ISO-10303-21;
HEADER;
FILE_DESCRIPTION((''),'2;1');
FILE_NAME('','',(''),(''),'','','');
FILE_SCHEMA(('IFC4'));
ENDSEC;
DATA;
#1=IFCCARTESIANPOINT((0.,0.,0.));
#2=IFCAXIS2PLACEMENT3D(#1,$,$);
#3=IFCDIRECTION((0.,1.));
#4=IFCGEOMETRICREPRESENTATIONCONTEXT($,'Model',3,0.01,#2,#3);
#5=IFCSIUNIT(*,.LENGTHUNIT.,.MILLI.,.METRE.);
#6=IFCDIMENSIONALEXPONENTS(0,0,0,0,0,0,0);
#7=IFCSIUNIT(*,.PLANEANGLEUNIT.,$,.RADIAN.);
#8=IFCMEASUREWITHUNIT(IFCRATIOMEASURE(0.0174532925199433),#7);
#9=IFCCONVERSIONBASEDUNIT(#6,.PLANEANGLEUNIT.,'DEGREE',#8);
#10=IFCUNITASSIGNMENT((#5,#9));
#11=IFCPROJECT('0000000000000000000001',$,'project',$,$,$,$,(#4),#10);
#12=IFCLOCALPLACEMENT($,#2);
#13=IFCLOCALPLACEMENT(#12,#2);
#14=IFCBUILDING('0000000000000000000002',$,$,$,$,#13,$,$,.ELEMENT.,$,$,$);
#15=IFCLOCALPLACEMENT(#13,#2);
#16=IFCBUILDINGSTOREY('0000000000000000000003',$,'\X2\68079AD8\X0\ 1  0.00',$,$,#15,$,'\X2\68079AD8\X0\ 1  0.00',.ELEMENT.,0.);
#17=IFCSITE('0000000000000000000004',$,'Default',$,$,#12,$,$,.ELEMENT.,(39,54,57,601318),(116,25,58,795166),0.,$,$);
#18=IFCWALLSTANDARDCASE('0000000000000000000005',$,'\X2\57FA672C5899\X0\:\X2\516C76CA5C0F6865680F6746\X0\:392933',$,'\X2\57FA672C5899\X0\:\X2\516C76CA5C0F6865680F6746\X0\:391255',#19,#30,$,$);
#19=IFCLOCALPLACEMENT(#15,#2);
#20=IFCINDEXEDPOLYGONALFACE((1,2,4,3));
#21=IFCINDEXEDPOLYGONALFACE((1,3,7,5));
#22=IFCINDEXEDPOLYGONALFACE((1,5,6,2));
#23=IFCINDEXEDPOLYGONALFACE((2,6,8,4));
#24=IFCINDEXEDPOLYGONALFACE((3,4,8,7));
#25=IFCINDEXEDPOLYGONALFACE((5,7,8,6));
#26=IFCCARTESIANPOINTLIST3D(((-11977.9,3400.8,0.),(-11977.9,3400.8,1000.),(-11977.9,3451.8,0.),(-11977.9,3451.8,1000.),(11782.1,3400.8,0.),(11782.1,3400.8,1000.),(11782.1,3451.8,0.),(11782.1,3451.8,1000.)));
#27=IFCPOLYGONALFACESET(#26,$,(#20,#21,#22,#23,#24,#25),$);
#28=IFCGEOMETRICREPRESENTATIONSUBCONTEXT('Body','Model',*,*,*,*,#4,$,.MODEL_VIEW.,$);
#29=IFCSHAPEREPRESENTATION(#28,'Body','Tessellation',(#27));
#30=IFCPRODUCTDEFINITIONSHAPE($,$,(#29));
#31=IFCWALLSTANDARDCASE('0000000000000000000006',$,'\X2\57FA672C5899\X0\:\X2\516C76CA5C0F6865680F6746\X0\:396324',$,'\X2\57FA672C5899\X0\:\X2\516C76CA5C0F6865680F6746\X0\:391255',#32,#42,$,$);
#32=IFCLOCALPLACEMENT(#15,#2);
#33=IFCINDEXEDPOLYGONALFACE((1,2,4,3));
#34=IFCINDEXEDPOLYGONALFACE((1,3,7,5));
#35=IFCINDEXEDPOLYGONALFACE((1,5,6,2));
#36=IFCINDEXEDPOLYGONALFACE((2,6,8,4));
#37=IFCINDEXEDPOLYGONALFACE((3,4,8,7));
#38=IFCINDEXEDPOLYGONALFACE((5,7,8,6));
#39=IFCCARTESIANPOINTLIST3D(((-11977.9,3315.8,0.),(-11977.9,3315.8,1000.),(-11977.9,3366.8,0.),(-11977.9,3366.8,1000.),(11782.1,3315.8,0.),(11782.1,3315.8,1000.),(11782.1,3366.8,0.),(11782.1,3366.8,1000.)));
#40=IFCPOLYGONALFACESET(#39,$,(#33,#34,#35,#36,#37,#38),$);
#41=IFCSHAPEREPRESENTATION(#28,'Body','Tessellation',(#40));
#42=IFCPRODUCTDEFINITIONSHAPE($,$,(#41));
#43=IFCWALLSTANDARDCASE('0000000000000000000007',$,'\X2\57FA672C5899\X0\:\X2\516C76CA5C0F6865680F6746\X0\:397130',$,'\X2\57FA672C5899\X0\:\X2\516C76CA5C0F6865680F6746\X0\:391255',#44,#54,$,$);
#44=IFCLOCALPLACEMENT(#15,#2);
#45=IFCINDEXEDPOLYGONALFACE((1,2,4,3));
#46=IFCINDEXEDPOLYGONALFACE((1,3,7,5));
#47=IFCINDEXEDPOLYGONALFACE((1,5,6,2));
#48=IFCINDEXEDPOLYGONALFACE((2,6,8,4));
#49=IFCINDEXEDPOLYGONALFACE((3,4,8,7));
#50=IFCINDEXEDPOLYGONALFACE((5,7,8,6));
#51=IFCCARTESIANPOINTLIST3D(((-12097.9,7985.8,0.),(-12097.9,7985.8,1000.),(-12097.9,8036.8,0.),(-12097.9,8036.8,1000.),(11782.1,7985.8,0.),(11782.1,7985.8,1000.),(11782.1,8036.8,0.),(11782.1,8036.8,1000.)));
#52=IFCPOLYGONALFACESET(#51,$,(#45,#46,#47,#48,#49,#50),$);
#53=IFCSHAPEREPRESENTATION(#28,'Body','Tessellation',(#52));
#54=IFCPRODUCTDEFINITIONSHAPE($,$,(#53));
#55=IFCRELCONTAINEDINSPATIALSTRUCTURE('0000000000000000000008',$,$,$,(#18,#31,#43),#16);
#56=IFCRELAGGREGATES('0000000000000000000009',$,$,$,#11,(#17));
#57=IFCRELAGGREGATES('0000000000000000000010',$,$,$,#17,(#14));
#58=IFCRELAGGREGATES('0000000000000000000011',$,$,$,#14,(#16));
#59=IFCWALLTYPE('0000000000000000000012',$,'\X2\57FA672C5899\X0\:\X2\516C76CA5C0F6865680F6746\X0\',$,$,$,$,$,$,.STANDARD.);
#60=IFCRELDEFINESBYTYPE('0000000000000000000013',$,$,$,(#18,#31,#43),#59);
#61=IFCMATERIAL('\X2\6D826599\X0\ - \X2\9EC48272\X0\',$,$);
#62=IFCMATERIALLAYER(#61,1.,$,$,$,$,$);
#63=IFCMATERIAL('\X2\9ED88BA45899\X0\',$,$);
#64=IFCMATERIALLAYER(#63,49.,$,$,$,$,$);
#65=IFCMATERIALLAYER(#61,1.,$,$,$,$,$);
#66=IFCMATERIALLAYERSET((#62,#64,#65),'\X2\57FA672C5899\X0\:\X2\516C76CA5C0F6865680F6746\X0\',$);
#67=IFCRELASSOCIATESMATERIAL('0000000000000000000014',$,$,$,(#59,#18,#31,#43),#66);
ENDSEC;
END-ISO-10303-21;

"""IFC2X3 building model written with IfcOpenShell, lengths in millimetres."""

from ifc_helpers import new_model, entity, si_unit, converted_unit, direction, frame, frame_2d, origin, place, context, subcontext, project, spatial, rectangle, extrude, material, layer, layer_set, layer_usage, type_object, element, save


model = new_model("IFC2X3")

# Units and contexts
model_context = context("Model", 3, precision=0.01, world=origin(), true_north=direction((0.0, 1.0)))
body_context = subcontext(model_context, "Body", "Model", "MODEL_VIEW")
ifc_project = project(units=[si_unit("LENGTHUNIT", "METRE", prefix="MILLI"), converted_unit("PLANEANGLEUNIT", "DEGREE", entity("IfcRatioMeasure", 0.0174532925199433), si_unit("PLANEANGLEUNIT", "RADIAN"), dimensions=[0, 0, 0, 0, 0, 0, 0])], contexts=[model_context])

# Site, building, storey
site_placement = place(None, origin())
site = spatial("IfcSite", under=ifc_project, at=site_placement, Name="Default", CompositionType="ELEMENT", RefLatitude=(39, 54, 57, 601318), RefLongitude=(116, 25, 58, 795166), RefElevation=0.0)
building_placement = place(site_placement, origin())
building = spatial("IfcBuilding", under=site, at=building_placement, CompositionType="ELEMENT")
storey_placement = place(building_placement, origin())
storey = spatial("IfcBuildingStorey", under=building, at=storey_placement, Name="标高 1  0.00", LongName="标高 1  0.00", CompositionType="ELEMENT", Elevation=0.0)

# Walls
ifc_material_1 = material(Name="涂料 - 黄色")
ifc_layer_1 = layer(ifc_material_1, 1.0)
ifc_material_2 = material(Name="默认墙")
ifc_layer_2 = layer(ifc_material_2, 49.0)
ifc_layer_3 = layer(ifc_material_1, 1.0)
ifc_layer_set_1 = layer_set([ifc_layer_1, ifc_layer_2, ifc_layer_3], Name="基本墙:公益小桥栏杆")
ifc_layer_usage_1 = layer_usage(ifc_layer_set_1, "AXIS2", "NEGATIVE", 25.5)
wall_type = type_object("IfcWallType", Name="基本墙:公益小桥栏杆", PredefinedType="STANDARD", material=ifc_layer_set_1)
wall_1_placement = place(storey_placement, frame((11782.1, 3426.3, 0.0), z_axis=(0.0, 0.0, 1.0), x_axis=(-1.0, 0.0, 0.0)))
element("IfcWallStandardCase", 1, at=wall_1_placement, inside=storey, type_object=wall_type, material=ifc_layer_usage_1, Name="基本墙:公益小桥栏杆:392933", ObjectType="基本墙:公益小桥栏杆:391255", context=body_context, shape_type="SweptSolid", body=[
    extrude(rectangle(XDim=23760.0, YDim=51.0, at=frame_2d((11880.0, 0.0), x_axis=(-1.0, 0.0))), origin(), (0.0, 0.0, 1.0), 1000.0),
])
ifc_layer_usage_2 = layer_usage(ifc_layer_set_1, "AXIS2", "NEGATIVE", 25.5)
wall_2_placement = place(storey_placement, frame((11782.1, 3341.3, 0.0), z_axis=(0.0, 0.0, 1.0), x_axis=(-1.0, 0.0, 0.0)))
element("IfcWallStandardCase", 2, at=wall_2_placement, inside=storey, type_object=wall_type, material=ifc_layer_usage_2, Name="基本墙:公益小桥栏杆:396324", ObjectType="基本墙:公益小桥栏杆:391255", context=body_context, shape_type="SweptSolid", body=[
    extrude(rectangle(XDim=23760.0, YDim=51.0, at=frame_2d((11880.0, 0.0), x_axis=(-1.0, 0.0))), origin(), (0.0, 0.0, 1.0), 1000.0),
])
ifc_layer_usage_3 = layer_usage(ifc_layer_set_1, "AXIS2", "NEGATIVE", 25.5)
wall_3_placement = place(storey_placement, frame((11782.1, 8011.3, 0.0), z_axis=(0.0, 0.0, 1.0), x_axis=(-1.0, 0.0, 0.0)))
element("IfcWallStandardCase", 3, at=wall_3_placement, inside=storey, type_object=wall_type, material=ifc_layer_usage_3, Name="基本墙:公益小桥栏杆:397130", ObjectType="基本墙:公益小桥栏杆:391255", context=body_context, shape_type="SweptSolid", body=[
    extrude(rectangle(XDim=23880.0, YDim=51.0, at=frame_2d((11940.0, 0.0), x_axis=(-1.0, 0.0))), origin(), (0.0, 0.0, 1.0), 1000.0),
])

save(model, "model.ifc")
